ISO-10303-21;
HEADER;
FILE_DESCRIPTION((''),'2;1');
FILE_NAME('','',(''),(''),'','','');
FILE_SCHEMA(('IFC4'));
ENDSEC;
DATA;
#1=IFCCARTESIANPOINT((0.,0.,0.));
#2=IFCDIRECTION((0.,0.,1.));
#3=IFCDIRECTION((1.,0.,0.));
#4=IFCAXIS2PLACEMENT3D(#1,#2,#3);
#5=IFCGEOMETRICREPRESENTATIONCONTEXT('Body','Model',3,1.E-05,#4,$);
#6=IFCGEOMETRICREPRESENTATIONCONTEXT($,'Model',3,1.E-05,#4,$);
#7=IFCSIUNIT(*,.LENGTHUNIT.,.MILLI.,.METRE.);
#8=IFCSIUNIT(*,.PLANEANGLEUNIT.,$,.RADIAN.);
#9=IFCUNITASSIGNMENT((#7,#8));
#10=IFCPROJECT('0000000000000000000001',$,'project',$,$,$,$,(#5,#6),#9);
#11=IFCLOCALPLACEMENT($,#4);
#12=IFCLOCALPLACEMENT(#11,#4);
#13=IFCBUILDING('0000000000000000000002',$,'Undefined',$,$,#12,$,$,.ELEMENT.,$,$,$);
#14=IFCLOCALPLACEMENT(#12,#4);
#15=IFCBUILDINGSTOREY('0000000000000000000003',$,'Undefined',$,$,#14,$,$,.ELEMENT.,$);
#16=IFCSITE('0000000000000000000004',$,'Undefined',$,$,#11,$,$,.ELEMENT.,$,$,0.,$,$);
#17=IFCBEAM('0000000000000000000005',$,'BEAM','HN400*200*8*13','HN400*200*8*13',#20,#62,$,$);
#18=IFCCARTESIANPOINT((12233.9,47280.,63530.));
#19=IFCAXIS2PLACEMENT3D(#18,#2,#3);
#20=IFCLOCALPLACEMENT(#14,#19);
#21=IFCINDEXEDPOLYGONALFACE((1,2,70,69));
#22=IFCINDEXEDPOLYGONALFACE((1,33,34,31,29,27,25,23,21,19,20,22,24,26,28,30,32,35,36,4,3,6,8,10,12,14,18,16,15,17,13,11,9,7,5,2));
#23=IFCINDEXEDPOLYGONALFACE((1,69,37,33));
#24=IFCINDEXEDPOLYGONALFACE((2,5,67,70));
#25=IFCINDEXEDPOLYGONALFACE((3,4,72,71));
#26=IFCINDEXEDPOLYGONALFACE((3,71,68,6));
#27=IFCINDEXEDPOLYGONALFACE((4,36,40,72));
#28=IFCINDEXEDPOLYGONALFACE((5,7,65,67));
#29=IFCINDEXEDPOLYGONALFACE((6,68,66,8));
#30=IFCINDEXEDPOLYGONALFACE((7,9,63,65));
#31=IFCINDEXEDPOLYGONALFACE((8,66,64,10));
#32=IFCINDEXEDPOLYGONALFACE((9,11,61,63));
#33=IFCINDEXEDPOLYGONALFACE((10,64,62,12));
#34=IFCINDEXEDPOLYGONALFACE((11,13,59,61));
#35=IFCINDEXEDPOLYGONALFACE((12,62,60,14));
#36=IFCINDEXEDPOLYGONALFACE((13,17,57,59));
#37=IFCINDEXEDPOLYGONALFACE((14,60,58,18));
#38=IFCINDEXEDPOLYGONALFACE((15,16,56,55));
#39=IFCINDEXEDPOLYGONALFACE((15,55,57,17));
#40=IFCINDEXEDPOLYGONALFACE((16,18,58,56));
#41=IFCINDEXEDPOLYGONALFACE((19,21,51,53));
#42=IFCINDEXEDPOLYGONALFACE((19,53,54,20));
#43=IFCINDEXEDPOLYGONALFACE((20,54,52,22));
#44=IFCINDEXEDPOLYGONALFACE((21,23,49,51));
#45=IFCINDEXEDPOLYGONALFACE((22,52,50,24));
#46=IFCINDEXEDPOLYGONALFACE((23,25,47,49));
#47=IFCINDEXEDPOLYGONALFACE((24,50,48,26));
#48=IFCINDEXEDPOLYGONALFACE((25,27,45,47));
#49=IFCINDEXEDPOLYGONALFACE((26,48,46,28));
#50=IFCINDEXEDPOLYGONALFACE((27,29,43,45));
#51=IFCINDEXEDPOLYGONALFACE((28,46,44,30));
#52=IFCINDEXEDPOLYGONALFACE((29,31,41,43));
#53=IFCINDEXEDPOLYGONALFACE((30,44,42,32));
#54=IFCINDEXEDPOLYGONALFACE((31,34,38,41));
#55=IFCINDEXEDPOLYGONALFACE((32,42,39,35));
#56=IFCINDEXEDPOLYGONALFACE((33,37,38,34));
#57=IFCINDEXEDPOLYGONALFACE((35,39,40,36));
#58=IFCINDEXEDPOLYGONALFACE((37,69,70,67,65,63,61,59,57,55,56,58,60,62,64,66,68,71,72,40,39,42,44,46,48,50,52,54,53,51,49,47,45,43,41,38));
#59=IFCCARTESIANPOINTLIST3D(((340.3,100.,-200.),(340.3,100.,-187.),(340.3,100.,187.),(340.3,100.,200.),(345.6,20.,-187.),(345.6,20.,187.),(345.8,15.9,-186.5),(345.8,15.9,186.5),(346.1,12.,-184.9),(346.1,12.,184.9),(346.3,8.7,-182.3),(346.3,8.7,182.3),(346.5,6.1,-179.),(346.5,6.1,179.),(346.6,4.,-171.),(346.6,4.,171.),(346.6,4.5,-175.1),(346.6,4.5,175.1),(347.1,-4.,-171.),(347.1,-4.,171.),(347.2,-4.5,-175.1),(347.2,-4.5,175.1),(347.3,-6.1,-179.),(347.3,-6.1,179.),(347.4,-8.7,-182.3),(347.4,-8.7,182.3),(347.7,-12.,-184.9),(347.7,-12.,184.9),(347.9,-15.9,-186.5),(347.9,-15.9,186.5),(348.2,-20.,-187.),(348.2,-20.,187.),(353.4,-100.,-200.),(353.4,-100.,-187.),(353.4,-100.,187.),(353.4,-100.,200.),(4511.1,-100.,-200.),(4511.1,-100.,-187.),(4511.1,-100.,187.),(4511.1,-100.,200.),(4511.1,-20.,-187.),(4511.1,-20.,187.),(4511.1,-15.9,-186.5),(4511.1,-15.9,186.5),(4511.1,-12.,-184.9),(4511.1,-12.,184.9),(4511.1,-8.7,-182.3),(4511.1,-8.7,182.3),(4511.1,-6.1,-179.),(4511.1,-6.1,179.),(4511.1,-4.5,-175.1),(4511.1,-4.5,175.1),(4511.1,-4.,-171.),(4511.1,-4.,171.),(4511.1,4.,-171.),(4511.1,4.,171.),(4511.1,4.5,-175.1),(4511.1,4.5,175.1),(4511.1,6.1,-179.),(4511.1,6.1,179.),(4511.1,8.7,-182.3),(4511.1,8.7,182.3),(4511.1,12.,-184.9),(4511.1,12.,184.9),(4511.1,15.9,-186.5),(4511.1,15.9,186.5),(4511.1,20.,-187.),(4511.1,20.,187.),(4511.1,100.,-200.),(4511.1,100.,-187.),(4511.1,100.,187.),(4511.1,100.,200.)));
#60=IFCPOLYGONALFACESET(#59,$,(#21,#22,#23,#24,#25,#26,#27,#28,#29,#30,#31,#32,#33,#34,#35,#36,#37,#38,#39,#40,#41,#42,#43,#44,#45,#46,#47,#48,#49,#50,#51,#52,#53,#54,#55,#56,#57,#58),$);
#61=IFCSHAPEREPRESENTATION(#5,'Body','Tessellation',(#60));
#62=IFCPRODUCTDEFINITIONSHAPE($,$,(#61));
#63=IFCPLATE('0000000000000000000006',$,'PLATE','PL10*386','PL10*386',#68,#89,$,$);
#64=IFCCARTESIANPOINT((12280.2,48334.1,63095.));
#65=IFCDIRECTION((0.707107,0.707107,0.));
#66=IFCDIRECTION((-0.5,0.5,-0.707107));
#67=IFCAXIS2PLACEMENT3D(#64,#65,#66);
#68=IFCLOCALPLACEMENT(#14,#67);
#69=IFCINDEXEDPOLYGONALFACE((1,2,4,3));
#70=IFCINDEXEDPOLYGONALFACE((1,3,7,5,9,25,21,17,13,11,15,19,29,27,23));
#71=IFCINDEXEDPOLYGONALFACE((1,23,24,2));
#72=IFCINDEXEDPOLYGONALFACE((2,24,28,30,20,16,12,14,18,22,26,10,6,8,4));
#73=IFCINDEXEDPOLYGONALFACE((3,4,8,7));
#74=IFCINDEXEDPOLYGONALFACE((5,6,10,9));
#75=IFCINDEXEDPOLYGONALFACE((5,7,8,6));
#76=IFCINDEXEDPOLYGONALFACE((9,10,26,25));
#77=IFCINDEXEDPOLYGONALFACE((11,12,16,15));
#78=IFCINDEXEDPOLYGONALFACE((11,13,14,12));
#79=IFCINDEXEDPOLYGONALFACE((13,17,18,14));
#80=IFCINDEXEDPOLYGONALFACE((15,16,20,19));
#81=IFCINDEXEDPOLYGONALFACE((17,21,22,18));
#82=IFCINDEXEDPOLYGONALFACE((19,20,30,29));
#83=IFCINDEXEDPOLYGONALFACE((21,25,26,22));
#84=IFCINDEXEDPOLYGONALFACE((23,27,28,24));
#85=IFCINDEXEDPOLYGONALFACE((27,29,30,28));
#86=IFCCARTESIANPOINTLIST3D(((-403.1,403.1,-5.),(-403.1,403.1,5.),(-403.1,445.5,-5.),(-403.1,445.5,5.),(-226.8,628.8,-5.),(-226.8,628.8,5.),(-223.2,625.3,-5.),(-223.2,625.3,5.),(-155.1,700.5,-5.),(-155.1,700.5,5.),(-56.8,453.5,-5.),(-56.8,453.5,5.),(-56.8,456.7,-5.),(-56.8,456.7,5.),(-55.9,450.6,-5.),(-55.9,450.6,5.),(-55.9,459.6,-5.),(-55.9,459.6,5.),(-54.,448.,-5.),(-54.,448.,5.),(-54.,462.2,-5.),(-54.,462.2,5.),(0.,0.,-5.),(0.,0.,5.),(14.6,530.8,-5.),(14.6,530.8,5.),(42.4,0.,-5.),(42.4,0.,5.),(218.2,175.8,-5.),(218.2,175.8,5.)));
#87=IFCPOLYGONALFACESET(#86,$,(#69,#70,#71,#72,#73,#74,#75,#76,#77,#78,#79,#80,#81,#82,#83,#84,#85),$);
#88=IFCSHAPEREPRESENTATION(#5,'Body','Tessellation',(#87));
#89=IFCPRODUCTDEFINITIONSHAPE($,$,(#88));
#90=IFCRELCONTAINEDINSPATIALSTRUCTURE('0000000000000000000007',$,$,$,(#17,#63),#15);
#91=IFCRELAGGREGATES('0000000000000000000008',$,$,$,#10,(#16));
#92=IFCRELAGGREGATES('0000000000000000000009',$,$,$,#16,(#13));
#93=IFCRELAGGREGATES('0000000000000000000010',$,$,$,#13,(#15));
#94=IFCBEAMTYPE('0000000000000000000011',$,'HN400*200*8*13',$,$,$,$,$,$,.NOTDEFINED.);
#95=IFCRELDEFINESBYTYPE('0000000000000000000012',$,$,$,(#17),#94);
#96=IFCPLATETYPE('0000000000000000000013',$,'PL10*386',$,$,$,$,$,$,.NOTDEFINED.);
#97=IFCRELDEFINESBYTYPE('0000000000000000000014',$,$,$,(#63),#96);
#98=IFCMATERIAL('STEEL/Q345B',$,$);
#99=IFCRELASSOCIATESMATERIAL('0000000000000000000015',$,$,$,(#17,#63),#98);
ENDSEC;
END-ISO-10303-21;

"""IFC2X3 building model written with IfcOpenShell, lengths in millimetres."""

from ifc_helpers import new_model, si_unit, frame, origin_with_axes, origin_2d_with_axis, place, context, project, spatial, polyline, i_section, outline, extrude, clip, halfspace, material, type_object, element, save


model = new_model("IFC2X3")

# Units and contexts
model_context_1 = context("Model", 3, precision=1e-05, world=origin_with_axes(), identifier="Body")
model_context_2 = context("Model", 3, precision=1e-05, world=origin_with_axes())
ifc_project = project(units=[si_unit("LENGTHUNIT", "METRE", prefix="MILLI"), si_unit("PLANEANGLEUNIT", "RADIAN")], contexts=[model_context_1, model_context_2])

# Site, building, storey
site_placement = place(None, origin_with_axes())
site = spatial("IfcSite", under=ifc_project, at=site_placement, Name="Undefined", CompositionType="ELEMENT", RefElevation=0.0)
building_placement = place(site_placement, origin_with_axes())
building = spatial("IfcBuilding", under=site, at=building_placement, Name="Undefined", CompositionType="ELEMENT")
storey_placement = place(building_placement, origin_with_axes())
storey = spatial("IfcBuildingStorey", under=building, at=storey_placement, Name="Undefined", CompositionType="ELEMENT")

# Beam
ifc_material_1 = material(Name="STEEL/Q345B")
beam_type_1 = type_object("IfcBeamType", Name="HN400*200*8*13", PredefinedType="NOTDEFINED")
beam_1_placement = place(storey_placement, frame((12233.9, 47280.0, 63530.0), z_axis=(0.0, 0.0, 1.0), x_axis=(1.0, 0.0, 0.0)))
element("IfcBeam", 1, at=beam_1_placement, inside=storey, type_object=beam_type_1, material=ifc_material_1, Name="BEAM", Description="HN400*200*8*13", ObjectType="HN400*200*8*13", context=model_context_1, shape_type="Clipping", body=[
    clip(clip(extrude(i_section(OverallWidth=200.0, OverallDepth=400.0, WebThickness=8.0, FlangeThickness=13.0, FilletRadius=16.0, at=origin_2d_with_axis()), frame((4511.1, 0.0, 0.0), z_axis=(-1.0, 0.0, 0.0), x_axis=(0.0, -1.0, 0.0)), (0.0, 0.0, 1.0), 4170.8), halfspace(frame((346.0, 13.2, 300.0), z_axis=(-0.997873, -0.065183, 0.0), x_axis=(0.0, 0.0, -1.0)), False)), halfspace(frame((4511.1, 0.0, 300.0), z_axis=(1.0, 0.0, 0.0), x_axis=(0.0, 1.0, 0.0)), False)),
])

# Plate
plate_type_1 = type_object("IfcPlateType", Name="PL10*386", PredefinedType="NOTDEFINED")
plate_1_placement = place(storey_placement, frame((12280.2, 48334.1, 63095.0), z_axis=(0.707107, 0.707107, 0.0), x_axis=(-0.5, 0.5, -0.707107)))
element("IfcPlate", 2, at=plate_1_placement, inside=storey, type_object=plate_type_1, material=ifc_material_1, Name="PLATE", Description="PL10*386", ObjectType="PL10*386", context=model_context_1, shape_type="SweptSolid", body=[
    extrude(outline(polyline([(0.0, 0.0), (42.4, 0.0), (218.2, 175.8), (-54.0, 448.0), (-55.9, 450.6), (-56.8, 453.5), (-56.8, 456.7), (-55.9, 459.6), (-54.0, 462.2), (14.6, 530.8), (-155.1, 700.5), (-226.8, 628.8), (-223.2, 625.3), (-403.1, 445.5), (-403.1, 403.1), (0.0, 0.0)])), frame((0.0, 0.0, -5.0), z_axis=(0.0, 0.0, 1.0), x_axis=(1.0, 0.0, 0.0)), (0.0, 0.0, 1.0), 10.0),
])

save(model, "model.ifc")
